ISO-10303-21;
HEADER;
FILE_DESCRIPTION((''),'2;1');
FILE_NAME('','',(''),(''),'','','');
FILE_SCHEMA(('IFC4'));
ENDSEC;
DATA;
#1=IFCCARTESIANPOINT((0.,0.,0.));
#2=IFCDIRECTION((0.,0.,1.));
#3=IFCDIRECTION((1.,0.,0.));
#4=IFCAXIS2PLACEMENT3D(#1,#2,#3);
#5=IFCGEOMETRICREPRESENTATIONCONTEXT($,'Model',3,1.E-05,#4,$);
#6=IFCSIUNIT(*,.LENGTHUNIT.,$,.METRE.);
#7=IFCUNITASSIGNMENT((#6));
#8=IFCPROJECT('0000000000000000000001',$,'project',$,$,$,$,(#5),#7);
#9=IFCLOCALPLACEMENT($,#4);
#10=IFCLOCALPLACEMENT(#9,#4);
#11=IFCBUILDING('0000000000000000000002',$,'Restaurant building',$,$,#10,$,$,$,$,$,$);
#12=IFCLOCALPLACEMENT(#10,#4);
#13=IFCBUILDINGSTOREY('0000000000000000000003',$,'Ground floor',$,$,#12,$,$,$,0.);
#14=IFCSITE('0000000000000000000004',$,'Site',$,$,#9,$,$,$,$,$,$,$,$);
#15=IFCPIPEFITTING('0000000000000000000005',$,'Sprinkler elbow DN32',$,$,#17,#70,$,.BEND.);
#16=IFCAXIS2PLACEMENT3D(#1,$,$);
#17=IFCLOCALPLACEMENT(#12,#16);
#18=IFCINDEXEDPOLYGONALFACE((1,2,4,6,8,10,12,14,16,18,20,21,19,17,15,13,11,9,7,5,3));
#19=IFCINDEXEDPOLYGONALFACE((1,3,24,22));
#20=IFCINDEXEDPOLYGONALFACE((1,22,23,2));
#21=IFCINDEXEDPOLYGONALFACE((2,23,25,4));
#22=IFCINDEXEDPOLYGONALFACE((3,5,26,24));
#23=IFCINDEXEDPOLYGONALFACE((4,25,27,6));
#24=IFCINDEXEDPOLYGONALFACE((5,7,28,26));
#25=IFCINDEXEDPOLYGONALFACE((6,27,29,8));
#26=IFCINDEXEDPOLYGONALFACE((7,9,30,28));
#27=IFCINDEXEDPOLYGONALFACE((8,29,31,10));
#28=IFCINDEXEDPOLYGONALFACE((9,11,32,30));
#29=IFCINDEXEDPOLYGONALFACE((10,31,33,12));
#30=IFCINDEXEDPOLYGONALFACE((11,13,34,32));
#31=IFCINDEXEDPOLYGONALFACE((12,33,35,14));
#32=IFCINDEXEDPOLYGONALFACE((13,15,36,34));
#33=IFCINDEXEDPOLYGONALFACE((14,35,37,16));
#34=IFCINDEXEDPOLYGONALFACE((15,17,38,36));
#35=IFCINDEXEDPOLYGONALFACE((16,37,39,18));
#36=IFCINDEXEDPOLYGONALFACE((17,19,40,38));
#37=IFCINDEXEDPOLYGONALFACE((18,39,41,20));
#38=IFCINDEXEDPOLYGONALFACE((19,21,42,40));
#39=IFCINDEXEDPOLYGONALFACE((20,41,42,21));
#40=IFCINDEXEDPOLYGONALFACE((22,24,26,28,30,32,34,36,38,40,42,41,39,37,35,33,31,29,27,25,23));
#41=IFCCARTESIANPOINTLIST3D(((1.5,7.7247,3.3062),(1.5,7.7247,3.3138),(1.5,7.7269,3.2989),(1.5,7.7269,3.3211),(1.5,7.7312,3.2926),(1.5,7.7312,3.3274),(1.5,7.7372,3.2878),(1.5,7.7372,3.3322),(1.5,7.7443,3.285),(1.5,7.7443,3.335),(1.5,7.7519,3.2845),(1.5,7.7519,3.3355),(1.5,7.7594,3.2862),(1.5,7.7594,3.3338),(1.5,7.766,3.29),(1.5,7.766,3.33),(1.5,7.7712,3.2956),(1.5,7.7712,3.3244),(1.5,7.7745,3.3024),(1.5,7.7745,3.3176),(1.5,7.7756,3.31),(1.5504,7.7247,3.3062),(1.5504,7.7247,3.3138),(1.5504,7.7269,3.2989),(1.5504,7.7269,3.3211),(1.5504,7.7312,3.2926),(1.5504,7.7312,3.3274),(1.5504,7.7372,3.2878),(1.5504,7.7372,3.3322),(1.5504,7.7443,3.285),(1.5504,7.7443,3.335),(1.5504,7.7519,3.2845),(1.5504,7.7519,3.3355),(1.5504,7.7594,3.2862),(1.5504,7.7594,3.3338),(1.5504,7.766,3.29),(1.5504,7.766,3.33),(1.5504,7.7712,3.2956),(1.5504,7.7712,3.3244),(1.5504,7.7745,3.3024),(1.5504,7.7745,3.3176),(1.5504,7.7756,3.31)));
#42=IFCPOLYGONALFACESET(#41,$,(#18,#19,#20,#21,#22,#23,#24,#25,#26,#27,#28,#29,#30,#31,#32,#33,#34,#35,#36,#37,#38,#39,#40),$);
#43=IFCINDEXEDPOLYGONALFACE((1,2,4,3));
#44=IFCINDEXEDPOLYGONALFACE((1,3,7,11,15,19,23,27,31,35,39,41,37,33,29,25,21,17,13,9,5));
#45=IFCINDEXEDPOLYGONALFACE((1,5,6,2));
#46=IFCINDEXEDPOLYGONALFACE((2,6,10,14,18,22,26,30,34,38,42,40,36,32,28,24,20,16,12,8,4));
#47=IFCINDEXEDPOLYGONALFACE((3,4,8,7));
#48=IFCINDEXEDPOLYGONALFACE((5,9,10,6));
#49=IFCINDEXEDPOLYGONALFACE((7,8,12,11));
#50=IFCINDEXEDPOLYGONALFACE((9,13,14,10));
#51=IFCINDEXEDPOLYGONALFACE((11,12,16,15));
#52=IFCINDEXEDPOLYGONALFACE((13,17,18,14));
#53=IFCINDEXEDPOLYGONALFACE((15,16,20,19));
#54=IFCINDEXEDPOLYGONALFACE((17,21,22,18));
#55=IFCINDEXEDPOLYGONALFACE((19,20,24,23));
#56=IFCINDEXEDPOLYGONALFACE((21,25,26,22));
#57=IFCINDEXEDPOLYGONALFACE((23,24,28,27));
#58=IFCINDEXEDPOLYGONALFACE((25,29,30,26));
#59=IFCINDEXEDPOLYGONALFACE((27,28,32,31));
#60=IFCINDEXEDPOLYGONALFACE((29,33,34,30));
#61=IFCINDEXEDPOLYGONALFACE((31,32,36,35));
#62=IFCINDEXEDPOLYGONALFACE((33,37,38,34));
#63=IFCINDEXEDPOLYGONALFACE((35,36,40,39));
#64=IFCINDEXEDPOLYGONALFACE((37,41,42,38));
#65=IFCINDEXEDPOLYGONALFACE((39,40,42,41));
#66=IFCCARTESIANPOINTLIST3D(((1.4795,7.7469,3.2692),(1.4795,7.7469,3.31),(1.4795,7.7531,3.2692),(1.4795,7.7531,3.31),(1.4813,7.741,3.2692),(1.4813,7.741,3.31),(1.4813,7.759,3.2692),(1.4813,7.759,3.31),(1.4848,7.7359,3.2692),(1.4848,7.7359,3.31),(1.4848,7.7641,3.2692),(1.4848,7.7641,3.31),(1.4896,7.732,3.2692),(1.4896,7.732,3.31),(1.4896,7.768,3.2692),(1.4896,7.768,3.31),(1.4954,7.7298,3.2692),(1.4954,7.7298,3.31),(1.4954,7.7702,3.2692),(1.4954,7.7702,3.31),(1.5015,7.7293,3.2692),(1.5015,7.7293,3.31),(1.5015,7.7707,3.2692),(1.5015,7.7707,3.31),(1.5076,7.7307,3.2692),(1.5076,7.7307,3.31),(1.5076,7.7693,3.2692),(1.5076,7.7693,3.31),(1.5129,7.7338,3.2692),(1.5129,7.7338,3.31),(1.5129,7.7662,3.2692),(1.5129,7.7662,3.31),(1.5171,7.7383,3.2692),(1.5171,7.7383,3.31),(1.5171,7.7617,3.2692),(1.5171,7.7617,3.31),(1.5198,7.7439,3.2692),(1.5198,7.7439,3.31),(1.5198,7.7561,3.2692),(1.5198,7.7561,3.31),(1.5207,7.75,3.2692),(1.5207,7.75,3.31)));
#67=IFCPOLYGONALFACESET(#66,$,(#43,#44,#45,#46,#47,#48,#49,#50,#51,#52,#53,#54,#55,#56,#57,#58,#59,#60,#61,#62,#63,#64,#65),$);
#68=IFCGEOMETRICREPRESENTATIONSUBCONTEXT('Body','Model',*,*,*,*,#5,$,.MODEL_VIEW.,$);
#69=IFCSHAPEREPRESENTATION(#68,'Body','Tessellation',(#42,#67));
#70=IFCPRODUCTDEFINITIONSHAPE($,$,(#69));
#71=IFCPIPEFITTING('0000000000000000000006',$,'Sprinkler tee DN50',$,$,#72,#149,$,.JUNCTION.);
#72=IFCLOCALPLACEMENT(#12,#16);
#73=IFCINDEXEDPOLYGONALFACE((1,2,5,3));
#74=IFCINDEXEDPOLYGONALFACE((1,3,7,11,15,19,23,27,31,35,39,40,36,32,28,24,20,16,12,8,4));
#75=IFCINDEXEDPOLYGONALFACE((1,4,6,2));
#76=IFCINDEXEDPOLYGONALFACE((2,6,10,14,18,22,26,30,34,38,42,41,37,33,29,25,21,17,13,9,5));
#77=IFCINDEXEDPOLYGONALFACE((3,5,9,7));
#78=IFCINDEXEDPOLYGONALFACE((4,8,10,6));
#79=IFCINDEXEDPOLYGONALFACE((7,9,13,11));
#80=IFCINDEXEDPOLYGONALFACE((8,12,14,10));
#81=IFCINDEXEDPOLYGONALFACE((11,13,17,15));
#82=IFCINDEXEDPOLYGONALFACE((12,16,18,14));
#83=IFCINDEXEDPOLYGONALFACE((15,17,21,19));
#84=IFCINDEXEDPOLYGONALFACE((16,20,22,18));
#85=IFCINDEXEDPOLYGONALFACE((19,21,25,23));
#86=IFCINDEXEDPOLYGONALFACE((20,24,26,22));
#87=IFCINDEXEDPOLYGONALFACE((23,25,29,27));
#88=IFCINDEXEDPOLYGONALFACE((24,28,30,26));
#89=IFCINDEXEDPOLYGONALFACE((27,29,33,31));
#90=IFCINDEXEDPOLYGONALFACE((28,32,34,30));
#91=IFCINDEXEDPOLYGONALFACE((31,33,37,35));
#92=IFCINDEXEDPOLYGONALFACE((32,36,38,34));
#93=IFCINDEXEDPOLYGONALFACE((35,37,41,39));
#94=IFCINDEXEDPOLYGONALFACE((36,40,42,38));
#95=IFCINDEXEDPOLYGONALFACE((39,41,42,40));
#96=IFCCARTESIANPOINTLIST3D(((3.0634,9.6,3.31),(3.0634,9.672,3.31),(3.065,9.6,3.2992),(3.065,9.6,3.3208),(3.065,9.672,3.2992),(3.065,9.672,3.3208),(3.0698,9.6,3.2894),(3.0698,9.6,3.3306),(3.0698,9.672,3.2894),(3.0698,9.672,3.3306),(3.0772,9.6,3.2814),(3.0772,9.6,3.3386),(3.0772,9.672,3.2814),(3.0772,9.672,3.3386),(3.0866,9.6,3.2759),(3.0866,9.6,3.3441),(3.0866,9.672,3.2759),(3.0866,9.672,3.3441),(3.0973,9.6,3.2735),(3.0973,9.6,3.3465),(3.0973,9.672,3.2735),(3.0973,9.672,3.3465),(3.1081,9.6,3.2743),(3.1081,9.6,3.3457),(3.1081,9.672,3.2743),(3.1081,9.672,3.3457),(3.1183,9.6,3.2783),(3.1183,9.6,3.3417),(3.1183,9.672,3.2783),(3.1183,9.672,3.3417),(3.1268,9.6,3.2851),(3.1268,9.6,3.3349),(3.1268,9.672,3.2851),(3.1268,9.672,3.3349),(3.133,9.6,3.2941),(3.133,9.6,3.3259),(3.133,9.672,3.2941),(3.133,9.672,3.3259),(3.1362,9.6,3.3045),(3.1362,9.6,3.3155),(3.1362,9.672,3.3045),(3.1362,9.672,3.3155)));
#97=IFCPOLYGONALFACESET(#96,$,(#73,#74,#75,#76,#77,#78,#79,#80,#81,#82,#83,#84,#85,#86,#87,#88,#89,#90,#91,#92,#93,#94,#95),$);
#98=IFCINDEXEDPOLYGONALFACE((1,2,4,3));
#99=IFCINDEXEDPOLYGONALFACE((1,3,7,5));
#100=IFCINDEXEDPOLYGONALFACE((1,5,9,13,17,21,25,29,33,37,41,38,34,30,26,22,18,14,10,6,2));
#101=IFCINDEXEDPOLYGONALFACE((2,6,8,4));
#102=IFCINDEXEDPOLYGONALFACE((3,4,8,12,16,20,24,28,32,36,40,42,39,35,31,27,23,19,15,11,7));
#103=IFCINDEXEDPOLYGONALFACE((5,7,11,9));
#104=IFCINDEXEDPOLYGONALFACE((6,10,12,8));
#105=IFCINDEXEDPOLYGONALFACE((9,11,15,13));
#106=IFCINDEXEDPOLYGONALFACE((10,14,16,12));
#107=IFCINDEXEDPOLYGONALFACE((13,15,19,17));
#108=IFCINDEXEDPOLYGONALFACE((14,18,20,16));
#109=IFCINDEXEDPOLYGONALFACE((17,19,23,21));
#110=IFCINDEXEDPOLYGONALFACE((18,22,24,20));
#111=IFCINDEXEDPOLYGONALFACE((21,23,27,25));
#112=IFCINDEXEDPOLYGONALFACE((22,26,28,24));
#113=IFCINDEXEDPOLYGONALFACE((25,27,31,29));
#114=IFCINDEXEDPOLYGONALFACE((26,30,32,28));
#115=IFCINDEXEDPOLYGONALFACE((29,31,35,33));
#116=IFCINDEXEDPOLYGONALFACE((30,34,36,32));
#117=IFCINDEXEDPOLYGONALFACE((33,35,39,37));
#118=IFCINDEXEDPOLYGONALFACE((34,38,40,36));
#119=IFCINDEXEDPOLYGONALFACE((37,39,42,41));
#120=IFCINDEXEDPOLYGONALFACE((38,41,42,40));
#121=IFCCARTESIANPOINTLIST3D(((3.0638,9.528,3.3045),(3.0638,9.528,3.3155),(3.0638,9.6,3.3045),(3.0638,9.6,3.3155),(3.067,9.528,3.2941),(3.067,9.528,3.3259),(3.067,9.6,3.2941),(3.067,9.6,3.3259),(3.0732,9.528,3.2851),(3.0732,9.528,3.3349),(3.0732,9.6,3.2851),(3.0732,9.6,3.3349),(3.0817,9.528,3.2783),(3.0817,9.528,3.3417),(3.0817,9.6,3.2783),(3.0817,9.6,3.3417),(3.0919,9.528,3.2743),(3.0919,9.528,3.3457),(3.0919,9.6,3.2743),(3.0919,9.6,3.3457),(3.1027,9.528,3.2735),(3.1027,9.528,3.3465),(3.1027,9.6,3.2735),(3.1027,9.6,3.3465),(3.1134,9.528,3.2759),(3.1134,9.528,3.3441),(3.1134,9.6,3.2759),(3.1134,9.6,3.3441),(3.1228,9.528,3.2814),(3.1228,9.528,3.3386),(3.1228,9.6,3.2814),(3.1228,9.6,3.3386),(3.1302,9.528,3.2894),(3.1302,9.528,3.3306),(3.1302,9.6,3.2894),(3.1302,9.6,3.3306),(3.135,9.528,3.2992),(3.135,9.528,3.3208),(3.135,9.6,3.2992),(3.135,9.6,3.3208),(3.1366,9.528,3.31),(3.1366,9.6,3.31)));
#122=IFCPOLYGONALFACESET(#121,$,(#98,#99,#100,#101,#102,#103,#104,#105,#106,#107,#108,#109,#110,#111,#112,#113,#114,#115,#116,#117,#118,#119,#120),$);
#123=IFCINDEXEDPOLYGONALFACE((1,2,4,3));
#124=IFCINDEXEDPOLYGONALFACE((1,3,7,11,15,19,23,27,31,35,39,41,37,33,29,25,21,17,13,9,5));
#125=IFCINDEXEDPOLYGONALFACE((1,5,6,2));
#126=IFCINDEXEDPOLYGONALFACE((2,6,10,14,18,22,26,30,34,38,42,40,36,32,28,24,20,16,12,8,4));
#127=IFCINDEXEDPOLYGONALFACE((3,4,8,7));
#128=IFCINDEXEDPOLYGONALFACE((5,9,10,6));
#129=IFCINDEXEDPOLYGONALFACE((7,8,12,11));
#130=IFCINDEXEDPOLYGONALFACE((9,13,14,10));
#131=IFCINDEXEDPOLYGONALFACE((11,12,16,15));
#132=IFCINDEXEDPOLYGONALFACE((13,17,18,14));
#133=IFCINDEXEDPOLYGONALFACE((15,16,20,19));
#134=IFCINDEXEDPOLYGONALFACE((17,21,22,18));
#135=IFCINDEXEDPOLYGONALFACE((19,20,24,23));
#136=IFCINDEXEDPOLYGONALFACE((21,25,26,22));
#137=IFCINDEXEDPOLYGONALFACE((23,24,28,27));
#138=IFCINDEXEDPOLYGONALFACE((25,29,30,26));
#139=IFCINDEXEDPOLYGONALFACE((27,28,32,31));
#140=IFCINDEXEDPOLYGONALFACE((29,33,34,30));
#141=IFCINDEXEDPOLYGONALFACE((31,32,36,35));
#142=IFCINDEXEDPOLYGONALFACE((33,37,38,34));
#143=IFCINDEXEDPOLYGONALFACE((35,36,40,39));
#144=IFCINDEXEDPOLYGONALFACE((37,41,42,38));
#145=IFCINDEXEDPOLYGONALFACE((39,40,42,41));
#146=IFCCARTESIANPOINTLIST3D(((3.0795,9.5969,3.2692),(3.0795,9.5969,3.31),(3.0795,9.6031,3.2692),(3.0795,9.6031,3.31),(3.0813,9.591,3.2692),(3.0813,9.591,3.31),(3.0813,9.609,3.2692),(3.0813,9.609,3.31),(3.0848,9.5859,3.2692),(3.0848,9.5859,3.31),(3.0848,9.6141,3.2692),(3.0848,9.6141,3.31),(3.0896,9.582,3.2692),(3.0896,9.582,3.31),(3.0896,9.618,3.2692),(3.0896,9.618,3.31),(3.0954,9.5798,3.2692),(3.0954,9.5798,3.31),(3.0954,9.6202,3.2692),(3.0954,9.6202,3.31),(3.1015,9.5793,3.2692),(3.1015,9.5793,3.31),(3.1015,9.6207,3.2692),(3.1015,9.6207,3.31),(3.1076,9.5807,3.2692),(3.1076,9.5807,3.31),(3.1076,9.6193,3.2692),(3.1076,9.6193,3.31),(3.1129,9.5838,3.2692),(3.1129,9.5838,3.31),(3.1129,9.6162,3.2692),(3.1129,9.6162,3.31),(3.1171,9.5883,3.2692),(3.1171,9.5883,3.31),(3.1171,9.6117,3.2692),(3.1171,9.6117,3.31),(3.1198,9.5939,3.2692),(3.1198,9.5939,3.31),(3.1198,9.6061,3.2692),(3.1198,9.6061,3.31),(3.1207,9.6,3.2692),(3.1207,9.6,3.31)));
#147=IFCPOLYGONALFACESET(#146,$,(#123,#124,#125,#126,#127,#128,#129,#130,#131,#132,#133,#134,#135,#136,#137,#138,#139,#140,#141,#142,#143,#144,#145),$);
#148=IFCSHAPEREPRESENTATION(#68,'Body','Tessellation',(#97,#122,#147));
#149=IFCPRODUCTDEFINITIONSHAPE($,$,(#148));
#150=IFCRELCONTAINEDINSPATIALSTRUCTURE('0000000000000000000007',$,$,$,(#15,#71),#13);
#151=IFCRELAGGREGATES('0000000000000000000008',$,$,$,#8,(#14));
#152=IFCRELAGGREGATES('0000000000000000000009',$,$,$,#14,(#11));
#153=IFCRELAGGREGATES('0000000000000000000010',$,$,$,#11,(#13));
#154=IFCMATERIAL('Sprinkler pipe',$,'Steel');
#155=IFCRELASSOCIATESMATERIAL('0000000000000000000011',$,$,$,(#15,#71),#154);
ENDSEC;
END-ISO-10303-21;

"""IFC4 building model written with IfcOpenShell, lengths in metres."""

from ifc_helpers import new_model, si_unit, frame, origin_with_axes, origin_2d, place, context, subcontext, project, spatial, circle, extrude, material, element, save


model = new_model("IFC4")

# Units and contexts
model_context = context("Model", 3, precision=1e-05, world=origin_with_axes())
body_context = subcontext(model_context, "Body", "Model", "MODEL_VIEW")
ifc_project = project(units=[si_unit("LENGTHUNIT", "METRE")], contexts=[model_context])

# Site, building, storey
site_placement = place(None, origin_with_axes())
site = spatial("IfcSite", under=ifc_project, at=site_placement, Name="Site")
building_placement = place(site_placement, origin_with_axes())
building = spatial("IfcBuilding", under=site, at=building_placement, Name="Restaurant building")
storey_placement = place(building_placement, origin_with_axes())
storey = spatial("IfcBuildingStorey", under=building, at=storey_placement, Name="Ground floor", Elevation=0.0)

# Shared definitions
ifc_material_1 = material(Name="Sprinkler pipe", Category="Steel")

# Pipe fittings
pipe_fitting_1_placement = place(storey_placement, frame((1.5, 7.75, 3.31)))
element("IfcPipeFitting", 1, at=pipe_fitting_1_placement, inside=storey, material=ifc_material_1, Name="Sprinkler elbow DN32", PredefinedType="BEND", context=body_context, shape_type="SweptSolid", body=[
    extrude(circle(Radius=0.0256, at=origin_2d()), frame((0.0, 0.0, 0.0), z_axis=(1.0, 0.0, 0.0), x_axis=(0.0, 1.0, 0.0)), (0.0, 0.0, 1.0), 0.0504),
    extrude(circle(Radius=0.0207, at=origin_2d()), frame((0.0, 0.0, 0.0), z_axis=(0.0, 0.0, -1.0), x_axis=(1.0, 0.0, 0.0)), (0.0, 0.0, 1.0), 0.0408),
])
pipe_fitting_2_placement = place(storey_placement, frame((3.1, 9.6, 3.31)))
element("IfcPipeFitting", 2, at=pipe_fitting_2_placement, inside=storey, material=ifc_material_1, Name="Sprinkler tee DN50", PredefinedType="JUNCTION", context=body_context, shape_type="SweptSolid", body=[
    extrude(circle(Radius=0.0366, at=origin_2d()), frame((0.0, 0.0, 0.0), z_axis=(0.0, 1.0, 0.0), x_axis=(-1.0, 0.0, 0.0)), (0.0, 0.0, 1.0), 0.072),
    extrude(circle(Radius=0.0366, at=origin_2d()), frame((0.0, 0.0, 0.0), z_axis=(0.0, -1.0, 0.0), x_axis=(1.0, 0.0, 0.0)), (0.0, 0.0, 1.0), 0.072),
    extrude(circle(Radius=0.0207, at=origin_2d()), frame((0.0, 0.0, 0.0), z_axis=(0.0, 0.0, -1.0), x_axis=(1.0, 0.0, 0.0)), (0.0, 0.0, 1.0), 0.0408),
])

save(model, "model.ifc")
